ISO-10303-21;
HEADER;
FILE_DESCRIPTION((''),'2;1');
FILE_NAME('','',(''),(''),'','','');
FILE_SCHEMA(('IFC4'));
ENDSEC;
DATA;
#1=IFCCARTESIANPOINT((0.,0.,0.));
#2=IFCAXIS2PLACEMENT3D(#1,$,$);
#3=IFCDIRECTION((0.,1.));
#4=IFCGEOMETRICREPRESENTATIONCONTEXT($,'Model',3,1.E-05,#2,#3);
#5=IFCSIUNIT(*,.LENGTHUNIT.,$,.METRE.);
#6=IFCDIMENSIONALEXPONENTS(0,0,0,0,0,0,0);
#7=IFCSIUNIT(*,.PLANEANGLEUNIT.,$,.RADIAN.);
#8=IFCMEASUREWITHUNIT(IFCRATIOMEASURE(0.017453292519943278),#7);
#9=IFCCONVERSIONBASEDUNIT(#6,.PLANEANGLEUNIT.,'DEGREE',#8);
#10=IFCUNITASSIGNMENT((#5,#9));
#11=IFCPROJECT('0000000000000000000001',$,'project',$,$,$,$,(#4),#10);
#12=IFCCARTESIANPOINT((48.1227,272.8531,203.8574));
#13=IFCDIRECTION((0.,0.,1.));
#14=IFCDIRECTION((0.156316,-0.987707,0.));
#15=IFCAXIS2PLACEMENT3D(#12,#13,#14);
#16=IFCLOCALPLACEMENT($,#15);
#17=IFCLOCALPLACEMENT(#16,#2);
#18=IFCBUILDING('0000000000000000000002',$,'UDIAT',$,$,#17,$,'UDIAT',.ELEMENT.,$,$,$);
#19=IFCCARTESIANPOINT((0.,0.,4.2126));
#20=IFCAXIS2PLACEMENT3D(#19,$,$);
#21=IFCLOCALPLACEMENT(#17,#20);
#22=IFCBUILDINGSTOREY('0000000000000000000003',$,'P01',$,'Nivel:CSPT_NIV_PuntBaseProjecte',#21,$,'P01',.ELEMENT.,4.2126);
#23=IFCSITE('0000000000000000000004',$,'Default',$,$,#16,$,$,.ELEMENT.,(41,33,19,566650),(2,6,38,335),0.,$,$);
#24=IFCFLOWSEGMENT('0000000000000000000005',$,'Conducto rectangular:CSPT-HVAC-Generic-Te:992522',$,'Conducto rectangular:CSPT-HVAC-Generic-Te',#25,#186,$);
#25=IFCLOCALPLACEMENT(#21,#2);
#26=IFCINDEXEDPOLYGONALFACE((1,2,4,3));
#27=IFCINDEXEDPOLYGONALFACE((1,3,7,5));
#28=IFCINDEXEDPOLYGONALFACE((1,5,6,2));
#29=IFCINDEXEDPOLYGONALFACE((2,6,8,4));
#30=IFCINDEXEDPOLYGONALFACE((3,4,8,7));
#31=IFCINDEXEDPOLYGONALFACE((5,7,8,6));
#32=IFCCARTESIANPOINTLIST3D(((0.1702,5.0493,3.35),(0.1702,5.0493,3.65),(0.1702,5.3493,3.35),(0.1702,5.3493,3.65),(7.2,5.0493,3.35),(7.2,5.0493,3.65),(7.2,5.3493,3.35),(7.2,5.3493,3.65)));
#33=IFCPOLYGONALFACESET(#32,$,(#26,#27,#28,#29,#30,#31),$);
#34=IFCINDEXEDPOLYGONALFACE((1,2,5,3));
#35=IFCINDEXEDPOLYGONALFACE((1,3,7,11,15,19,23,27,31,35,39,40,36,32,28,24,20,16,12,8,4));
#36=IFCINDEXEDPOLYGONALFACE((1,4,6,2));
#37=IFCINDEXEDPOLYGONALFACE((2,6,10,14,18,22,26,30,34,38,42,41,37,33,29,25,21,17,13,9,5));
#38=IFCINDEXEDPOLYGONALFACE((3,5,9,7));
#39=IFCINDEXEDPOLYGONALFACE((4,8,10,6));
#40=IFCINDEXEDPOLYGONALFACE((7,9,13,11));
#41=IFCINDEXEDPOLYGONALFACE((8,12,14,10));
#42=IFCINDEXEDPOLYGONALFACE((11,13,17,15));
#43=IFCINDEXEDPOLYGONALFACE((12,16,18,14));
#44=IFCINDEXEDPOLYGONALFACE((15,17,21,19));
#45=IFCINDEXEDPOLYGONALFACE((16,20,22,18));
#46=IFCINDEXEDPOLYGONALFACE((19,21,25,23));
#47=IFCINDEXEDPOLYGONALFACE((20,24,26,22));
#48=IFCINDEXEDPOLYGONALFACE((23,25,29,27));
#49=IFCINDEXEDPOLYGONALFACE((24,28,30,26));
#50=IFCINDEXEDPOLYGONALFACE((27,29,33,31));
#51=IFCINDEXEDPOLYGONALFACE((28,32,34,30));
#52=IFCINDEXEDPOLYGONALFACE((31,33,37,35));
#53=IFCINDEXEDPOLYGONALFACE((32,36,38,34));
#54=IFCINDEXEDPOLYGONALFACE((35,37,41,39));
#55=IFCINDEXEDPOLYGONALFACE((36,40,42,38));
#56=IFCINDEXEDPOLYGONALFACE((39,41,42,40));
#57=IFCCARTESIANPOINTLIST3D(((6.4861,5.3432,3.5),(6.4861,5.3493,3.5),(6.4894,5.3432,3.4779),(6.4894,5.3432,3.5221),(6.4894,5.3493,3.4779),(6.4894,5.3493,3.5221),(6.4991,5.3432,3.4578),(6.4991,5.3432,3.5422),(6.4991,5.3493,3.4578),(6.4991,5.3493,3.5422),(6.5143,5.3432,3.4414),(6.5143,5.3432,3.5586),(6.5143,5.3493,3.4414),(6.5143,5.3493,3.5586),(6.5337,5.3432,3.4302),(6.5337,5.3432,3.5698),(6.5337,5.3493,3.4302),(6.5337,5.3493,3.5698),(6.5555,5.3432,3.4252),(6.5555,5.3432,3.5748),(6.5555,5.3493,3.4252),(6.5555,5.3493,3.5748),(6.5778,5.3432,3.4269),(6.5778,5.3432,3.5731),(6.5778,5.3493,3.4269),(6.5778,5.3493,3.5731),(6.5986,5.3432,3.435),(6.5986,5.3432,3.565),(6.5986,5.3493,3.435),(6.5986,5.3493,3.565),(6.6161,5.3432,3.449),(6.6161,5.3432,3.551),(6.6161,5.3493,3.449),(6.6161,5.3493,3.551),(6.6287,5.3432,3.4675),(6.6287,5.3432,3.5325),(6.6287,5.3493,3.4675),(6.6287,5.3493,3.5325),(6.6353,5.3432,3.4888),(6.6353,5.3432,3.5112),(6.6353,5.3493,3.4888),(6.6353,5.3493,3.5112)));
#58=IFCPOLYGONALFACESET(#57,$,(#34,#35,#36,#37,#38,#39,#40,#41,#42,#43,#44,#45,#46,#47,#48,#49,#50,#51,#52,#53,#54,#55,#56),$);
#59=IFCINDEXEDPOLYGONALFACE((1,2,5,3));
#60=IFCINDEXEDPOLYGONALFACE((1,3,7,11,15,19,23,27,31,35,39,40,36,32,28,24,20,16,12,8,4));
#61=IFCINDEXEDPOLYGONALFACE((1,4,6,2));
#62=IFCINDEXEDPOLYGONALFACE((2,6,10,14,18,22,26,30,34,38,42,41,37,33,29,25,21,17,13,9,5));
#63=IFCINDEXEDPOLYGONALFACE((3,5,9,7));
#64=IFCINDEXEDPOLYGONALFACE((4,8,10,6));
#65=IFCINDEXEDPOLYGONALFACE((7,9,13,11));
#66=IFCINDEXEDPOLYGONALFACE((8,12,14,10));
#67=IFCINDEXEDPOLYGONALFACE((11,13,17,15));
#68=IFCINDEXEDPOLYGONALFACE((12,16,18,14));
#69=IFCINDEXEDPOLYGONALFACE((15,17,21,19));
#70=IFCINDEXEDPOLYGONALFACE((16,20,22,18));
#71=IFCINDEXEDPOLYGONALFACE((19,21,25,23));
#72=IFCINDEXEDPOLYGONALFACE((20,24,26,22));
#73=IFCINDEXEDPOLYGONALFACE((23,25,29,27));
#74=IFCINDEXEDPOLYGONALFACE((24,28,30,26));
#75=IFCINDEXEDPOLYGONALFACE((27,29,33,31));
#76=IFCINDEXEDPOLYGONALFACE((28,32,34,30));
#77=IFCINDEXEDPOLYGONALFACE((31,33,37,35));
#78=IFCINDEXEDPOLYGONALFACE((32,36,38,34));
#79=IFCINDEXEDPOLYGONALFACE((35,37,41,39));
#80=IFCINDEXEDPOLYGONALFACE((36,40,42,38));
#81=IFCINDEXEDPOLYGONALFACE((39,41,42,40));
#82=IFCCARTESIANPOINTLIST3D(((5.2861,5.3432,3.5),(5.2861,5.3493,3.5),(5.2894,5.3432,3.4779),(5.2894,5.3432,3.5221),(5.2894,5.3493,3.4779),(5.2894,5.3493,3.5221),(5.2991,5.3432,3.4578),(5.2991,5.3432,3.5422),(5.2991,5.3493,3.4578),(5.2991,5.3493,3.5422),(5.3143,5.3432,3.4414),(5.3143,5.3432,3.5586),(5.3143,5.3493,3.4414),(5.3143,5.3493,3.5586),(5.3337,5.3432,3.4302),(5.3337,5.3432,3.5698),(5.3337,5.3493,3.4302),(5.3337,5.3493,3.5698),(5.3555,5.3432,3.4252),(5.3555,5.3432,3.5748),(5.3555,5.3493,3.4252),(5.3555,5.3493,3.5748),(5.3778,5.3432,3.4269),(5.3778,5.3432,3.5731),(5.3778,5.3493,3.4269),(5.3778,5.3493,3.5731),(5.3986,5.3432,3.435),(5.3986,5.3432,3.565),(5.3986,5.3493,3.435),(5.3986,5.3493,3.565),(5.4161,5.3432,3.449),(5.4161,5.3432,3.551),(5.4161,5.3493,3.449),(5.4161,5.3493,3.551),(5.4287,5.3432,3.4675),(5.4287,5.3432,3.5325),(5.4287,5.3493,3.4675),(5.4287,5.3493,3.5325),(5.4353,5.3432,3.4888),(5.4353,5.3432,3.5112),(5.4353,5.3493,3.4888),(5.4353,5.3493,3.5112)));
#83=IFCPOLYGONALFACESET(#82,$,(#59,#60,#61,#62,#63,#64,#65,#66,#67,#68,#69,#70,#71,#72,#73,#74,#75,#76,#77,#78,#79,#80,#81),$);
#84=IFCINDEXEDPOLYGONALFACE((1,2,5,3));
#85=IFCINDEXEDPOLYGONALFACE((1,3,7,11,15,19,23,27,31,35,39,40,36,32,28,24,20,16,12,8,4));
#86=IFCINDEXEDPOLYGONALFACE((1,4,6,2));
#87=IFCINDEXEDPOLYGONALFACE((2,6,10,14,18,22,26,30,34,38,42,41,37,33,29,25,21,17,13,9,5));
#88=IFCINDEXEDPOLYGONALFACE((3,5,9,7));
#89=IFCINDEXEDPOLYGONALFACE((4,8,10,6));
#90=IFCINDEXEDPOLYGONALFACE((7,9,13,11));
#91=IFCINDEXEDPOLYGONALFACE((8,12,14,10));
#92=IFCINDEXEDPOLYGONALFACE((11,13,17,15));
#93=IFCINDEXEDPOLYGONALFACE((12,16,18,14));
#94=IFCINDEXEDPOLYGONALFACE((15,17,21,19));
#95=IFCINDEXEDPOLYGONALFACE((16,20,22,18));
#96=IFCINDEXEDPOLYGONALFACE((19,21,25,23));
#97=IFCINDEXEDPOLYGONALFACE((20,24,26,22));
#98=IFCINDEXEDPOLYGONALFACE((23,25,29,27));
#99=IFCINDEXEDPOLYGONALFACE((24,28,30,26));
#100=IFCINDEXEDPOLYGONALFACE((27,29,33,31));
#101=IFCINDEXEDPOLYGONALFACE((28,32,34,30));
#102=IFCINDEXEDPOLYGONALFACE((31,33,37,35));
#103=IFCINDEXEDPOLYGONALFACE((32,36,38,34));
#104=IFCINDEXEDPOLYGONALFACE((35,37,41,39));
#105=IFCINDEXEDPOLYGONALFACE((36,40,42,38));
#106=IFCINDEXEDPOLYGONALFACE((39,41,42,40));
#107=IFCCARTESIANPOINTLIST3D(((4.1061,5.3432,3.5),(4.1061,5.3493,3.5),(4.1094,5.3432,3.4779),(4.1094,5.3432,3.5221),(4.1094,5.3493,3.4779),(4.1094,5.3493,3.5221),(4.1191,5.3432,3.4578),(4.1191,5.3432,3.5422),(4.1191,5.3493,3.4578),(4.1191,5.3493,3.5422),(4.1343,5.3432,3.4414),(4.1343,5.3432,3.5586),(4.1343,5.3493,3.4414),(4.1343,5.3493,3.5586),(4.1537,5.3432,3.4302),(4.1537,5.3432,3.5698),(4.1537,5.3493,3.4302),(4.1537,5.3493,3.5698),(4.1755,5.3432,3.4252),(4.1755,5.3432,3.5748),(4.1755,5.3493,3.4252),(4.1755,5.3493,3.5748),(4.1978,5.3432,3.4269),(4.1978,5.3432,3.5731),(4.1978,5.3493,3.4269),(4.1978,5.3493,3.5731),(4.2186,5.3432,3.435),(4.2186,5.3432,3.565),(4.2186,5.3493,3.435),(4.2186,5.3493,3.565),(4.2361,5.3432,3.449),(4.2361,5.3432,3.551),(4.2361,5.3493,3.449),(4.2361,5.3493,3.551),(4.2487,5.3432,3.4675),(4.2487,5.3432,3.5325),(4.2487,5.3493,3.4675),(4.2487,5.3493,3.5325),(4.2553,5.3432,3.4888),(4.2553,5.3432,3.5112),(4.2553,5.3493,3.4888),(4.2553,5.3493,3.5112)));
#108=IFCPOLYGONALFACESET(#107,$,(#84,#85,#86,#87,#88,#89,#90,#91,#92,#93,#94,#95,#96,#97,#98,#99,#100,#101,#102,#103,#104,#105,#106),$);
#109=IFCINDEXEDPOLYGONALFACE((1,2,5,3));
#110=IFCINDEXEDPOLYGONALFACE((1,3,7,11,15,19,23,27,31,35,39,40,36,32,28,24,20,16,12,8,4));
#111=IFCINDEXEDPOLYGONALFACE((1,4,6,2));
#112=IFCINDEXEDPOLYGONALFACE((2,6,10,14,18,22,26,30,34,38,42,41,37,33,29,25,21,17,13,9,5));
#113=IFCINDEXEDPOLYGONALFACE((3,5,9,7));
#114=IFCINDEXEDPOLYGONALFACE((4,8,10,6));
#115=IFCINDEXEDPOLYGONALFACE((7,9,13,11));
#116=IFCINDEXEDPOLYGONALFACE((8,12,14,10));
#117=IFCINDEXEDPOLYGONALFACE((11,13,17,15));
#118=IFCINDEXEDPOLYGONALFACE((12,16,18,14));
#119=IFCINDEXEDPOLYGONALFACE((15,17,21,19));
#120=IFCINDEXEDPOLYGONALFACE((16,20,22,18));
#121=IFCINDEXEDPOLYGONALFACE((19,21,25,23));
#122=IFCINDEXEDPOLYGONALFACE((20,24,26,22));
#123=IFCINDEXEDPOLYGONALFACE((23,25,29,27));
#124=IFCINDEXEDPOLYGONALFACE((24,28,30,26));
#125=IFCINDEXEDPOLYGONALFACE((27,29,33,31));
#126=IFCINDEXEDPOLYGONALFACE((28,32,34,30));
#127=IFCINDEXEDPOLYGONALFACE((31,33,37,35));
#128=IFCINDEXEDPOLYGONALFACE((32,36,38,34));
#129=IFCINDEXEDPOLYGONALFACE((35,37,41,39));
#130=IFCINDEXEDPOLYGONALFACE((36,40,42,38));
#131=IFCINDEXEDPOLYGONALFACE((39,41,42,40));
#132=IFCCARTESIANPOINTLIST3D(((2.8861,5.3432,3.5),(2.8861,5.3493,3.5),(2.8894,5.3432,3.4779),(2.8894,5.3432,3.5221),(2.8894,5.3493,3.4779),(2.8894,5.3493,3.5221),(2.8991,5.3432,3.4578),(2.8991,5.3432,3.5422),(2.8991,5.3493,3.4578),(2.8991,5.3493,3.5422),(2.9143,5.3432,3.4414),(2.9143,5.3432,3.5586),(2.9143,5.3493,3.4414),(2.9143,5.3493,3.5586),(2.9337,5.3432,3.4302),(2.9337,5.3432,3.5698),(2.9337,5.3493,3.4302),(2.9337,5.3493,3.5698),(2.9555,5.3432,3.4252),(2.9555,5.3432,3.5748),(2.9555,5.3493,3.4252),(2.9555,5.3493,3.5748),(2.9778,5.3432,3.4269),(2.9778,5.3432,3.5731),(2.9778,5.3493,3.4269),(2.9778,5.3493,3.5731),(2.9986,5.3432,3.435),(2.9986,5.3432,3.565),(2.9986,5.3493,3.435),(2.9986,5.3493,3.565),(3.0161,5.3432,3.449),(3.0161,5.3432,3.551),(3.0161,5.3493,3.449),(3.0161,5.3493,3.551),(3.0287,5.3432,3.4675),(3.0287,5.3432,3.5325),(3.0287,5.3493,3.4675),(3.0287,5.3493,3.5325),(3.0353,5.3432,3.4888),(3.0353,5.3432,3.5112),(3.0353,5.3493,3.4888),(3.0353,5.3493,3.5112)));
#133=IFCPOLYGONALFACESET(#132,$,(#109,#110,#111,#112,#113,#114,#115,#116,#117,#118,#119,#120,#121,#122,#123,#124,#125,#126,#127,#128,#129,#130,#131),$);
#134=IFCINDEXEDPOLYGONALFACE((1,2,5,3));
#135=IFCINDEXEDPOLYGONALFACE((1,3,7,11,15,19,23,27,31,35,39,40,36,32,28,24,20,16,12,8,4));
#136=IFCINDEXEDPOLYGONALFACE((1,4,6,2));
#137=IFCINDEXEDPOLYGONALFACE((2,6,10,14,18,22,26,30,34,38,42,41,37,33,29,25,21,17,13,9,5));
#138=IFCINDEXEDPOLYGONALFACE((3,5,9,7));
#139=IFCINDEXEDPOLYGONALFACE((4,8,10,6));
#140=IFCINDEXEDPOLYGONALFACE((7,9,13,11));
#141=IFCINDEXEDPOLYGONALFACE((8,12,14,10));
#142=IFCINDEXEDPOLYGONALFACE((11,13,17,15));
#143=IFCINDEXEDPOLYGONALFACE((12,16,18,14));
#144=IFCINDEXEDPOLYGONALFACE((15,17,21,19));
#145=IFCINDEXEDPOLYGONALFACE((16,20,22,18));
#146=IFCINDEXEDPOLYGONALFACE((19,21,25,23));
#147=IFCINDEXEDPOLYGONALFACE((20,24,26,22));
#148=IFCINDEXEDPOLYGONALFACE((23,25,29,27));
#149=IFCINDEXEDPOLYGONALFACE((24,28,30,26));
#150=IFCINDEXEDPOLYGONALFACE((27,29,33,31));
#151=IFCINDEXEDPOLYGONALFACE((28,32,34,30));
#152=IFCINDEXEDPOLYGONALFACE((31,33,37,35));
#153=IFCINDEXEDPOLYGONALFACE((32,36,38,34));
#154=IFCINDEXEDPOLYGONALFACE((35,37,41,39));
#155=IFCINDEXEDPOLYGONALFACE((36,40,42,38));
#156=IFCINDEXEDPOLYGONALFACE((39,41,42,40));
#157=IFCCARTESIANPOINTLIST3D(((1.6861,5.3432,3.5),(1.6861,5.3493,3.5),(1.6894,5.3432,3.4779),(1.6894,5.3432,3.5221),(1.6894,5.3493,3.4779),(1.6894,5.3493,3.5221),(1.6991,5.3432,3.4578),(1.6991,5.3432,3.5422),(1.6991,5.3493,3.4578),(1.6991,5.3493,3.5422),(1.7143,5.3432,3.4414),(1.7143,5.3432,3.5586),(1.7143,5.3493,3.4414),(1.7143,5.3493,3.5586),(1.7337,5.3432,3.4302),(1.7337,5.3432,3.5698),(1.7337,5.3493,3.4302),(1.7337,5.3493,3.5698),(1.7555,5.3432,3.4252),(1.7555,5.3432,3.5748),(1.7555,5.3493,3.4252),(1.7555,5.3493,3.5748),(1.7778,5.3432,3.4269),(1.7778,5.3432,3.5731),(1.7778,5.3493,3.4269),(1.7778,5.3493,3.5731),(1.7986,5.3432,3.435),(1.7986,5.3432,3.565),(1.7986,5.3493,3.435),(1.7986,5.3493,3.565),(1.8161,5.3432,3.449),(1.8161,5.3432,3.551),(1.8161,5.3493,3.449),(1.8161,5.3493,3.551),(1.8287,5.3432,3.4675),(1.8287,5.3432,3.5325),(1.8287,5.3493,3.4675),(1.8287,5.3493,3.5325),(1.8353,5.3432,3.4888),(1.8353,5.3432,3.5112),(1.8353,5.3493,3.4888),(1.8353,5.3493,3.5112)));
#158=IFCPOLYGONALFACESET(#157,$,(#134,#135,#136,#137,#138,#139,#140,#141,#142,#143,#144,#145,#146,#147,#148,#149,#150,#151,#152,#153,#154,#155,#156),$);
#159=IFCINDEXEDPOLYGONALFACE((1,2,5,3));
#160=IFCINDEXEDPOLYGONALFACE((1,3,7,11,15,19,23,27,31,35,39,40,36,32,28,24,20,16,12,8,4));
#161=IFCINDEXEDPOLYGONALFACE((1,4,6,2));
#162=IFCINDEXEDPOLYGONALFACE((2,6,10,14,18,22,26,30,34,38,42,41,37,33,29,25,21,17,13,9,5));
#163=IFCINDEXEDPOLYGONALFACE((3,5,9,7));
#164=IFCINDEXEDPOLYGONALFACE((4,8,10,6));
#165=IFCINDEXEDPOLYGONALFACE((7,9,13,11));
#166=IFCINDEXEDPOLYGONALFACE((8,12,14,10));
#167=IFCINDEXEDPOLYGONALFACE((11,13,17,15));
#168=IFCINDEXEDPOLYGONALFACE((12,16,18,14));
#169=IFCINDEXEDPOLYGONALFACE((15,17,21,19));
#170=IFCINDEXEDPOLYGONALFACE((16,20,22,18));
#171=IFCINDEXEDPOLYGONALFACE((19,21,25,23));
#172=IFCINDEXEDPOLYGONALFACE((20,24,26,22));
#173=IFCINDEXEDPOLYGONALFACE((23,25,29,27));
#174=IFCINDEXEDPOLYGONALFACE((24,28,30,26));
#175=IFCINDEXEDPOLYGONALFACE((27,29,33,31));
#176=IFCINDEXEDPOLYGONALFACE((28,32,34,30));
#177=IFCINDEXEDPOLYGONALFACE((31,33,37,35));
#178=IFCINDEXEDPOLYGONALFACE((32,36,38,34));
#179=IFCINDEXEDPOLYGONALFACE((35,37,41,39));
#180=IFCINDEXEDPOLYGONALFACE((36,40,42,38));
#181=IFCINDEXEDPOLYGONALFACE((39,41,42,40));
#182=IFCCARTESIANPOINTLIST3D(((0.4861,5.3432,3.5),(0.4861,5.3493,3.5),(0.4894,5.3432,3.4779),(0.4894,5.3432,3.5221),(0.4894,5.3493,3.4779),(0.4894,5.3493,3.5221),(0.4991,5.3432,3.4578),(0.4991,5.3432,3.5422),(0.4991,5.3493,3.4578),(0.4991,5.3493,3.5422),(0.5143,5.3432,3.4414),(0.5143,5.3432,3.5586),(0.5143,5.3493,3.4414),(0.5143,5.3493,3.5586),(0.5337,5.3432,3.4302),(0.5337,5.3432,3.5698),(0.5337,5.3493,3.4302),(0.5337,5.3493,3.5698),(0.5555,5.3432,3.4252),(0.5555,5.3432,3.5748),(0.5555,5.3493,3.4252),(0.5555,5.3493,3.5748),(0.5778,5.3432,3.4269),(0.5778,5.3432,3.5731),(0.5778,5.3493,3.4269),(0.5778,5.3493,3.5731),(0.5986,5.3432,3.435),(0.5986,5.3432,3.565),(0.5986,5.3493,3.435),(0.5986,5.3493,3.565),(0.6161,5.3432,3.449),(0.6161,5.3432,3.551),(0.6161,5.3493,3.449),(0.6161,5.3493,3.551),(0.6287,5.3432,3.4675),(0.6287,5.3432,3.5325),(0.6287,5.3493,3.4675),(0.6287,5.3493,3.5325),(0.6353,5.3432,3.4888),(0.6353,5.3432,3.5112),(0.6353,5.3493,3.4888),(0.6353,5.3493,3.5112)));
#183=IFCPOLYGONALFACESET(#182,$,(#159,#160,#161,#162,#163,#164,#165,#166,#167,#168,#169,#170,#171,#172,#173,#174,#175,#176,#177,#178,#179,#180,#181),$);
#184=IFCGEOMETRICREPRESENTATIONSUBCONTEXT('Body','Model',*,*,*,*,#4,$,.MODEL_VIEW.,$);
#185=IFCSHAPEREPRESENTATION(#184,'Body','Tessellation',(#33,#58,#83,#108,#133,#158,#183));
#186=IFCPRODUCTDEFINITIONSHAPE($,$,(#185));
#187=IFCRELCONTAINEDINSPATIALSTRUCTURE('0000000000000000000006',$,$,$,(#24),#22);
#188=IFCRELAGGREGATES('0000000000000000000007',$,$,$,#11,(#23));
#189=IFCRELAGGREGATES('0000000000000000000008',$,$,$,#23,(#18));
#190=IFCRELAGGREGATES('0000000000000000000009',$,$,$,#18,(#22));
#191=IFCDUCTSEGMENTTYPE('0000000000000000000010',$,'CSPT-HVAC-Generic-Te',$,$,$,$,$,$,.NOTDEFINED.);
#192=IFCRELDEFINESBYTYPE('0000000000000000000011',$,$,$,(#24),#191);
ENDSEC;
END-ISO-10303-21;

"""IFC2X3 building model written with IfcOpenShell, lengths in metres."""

from ifc_helpers import new_model, entity, si_unit, converted_unit, direction, frame, frame_2d, origin, place, context, subcontext, project, spatial, rectangle, circle, extrude, type_object, element, save


model = new_model("IFC2X3")

# Units and contexts
model_context = context("Model", 3, precision=1e-05, world=origin(), true_north=direction((0.0, 1.0)))
body_context = subcontext(model_context, "Body", "Model", "MODEL_VIEW")
ifc_project = project(units=[si_unit("LENGTHUNIT", "METRE"), converted_unit("PLANEANGLEUNIT", "DEGREE", entity("IfcRatioMeasure", 0.017453292519943278), si_unit("PLANEANGLEUNIT", "RADIAN"), dimensions=[0, 0, 0, 0, 0, 0, 0])], contexts=[model_context])

# Site, building, storey
site_placement = place(None, frame((48.1227, 272.8531, 203.8574), z_axis=(0.0, 0.0, 1.0), x_axis=(0.156316, -0.987707, 0.0)))
site = spatial("IfcSite", under=ifc_project, at=site_placement, Name="Default", CompositionType="ELEMENT", RefLatitude=(41, 33, 19, 566650), RefLongitude=(2, 6, 38, 335), RefElevation=0.0)
building_placement = place(site_placement, origin())
building = spatial("IfcBuilding", under=site, at=building_placement, Name="UDIAT", LongName="UDIAT", CompositionType="ELEMENT")
storey_placement = place(building_placement, frame((0.0, 0.0, 4.2126)))
storey = spatial("IfcBuildingStorey", under=building, at=storey_placement, Name="P01", ObjectType="Nivel:CSPT_NIV_PuntBaseProjecte", LongName="P01", CompositionType="ELEMENT", Elevation=4.2126)

# Flow segment
duct_segment_type = type_object("IfcDuctSegmentType", Name="CSPT-HVAC-Generic-Te", PredefinedType="NOTDEFINED")
flow_segment_1_placement = place(storey_placement, origin())
element("IfcFlowSegment", 1, at=flow_segment_1_placement, inside=storey, type_object=duct_segment_type, Name="Conducto rectangular:CSPT-HVAC-Generic-Te:992522", ObjectType="Conducto rectangular:CSPT-HVAC-Generic-Te", context=body_context, shape_type="SweptSolid", body=[
    extrude(rectangle(XDim=7.0298, YDim=0.3, at=frame_2d((0.0, 0.0), x_axis=(1.0, 0.0))), frame((3.6851, 5.1993, 3.35)), (0.0, 0.0, 1.0), 0.3),
    extrude(circle(Radius=0.075, at=frame_2d((0.0, 0.0), x_axis=(1.0, 0.0))), frame((6.5611, 5.3432, 3.5), z_axis=(0.0, 1.0, 0.0), x_axis=(-1.0, 0.0, 0.0)), (0.0, 0.0, 1.0), 0.0061),
    extrude(circle(Radius=0.075, at=frame_2d((0.0, 0.0), x_axis=(1.0, 0.0))), frame((5.3611, 5.3432, 3.5), z_axis=(0.0, 1.0, 0.0), x_axis=(-1.0, 0.0, 0.0)), (0.0, 0.0, 1.0), 0.0061),
    extrude(circle(Radius=0.075, at=frame_2d((0.0, 0.0), x_axis=(1.0, 0.0))), frame((4.1811, 5.3432, 3.5), z_axis=(0.0, 1.0, 0.0), x_axis=(-1.0, 0.0, 0.0)), (0.0, 0.0, 1.0), 0.0061),
    extrude(circle(Radius=0.075, at=frame_2d((0.0, 0.0), x_axis=(1.0, 0.0))), frame((2.9611, 5.3432, 3.5), z_axis=(0.0, 1.0, 0.0), x_axis=(-1.0, 0.0, 0.0)), (0.0, 0.0, 1.0), 0.0061),
    extrude(circle(Radius=0.075, at=frame_2d((0.0, 0.0), x_axis=(1.0, 0.0))), frame((1.7611, 5.3432, 3.5), z_axis=(0.0, 1.0, 0.0), x_axis=(-1.0, 0.0, 0.0)), (0.0, 0.0, 1.0), 0.0061),
    extrude(circle(Radius=0.075, at=frame_2d((0.0, 0.0), x_axis=(1.0, 0.0))), frame((0.5611, 5.3432, 3.5), z_axis=(0.0, 1.0, 0.0), x_axis=(-1.0, 0.0, 0.0)), (0.0, 0.0, 1.0), 0.0061),
])

save(model, "model.ifc")
